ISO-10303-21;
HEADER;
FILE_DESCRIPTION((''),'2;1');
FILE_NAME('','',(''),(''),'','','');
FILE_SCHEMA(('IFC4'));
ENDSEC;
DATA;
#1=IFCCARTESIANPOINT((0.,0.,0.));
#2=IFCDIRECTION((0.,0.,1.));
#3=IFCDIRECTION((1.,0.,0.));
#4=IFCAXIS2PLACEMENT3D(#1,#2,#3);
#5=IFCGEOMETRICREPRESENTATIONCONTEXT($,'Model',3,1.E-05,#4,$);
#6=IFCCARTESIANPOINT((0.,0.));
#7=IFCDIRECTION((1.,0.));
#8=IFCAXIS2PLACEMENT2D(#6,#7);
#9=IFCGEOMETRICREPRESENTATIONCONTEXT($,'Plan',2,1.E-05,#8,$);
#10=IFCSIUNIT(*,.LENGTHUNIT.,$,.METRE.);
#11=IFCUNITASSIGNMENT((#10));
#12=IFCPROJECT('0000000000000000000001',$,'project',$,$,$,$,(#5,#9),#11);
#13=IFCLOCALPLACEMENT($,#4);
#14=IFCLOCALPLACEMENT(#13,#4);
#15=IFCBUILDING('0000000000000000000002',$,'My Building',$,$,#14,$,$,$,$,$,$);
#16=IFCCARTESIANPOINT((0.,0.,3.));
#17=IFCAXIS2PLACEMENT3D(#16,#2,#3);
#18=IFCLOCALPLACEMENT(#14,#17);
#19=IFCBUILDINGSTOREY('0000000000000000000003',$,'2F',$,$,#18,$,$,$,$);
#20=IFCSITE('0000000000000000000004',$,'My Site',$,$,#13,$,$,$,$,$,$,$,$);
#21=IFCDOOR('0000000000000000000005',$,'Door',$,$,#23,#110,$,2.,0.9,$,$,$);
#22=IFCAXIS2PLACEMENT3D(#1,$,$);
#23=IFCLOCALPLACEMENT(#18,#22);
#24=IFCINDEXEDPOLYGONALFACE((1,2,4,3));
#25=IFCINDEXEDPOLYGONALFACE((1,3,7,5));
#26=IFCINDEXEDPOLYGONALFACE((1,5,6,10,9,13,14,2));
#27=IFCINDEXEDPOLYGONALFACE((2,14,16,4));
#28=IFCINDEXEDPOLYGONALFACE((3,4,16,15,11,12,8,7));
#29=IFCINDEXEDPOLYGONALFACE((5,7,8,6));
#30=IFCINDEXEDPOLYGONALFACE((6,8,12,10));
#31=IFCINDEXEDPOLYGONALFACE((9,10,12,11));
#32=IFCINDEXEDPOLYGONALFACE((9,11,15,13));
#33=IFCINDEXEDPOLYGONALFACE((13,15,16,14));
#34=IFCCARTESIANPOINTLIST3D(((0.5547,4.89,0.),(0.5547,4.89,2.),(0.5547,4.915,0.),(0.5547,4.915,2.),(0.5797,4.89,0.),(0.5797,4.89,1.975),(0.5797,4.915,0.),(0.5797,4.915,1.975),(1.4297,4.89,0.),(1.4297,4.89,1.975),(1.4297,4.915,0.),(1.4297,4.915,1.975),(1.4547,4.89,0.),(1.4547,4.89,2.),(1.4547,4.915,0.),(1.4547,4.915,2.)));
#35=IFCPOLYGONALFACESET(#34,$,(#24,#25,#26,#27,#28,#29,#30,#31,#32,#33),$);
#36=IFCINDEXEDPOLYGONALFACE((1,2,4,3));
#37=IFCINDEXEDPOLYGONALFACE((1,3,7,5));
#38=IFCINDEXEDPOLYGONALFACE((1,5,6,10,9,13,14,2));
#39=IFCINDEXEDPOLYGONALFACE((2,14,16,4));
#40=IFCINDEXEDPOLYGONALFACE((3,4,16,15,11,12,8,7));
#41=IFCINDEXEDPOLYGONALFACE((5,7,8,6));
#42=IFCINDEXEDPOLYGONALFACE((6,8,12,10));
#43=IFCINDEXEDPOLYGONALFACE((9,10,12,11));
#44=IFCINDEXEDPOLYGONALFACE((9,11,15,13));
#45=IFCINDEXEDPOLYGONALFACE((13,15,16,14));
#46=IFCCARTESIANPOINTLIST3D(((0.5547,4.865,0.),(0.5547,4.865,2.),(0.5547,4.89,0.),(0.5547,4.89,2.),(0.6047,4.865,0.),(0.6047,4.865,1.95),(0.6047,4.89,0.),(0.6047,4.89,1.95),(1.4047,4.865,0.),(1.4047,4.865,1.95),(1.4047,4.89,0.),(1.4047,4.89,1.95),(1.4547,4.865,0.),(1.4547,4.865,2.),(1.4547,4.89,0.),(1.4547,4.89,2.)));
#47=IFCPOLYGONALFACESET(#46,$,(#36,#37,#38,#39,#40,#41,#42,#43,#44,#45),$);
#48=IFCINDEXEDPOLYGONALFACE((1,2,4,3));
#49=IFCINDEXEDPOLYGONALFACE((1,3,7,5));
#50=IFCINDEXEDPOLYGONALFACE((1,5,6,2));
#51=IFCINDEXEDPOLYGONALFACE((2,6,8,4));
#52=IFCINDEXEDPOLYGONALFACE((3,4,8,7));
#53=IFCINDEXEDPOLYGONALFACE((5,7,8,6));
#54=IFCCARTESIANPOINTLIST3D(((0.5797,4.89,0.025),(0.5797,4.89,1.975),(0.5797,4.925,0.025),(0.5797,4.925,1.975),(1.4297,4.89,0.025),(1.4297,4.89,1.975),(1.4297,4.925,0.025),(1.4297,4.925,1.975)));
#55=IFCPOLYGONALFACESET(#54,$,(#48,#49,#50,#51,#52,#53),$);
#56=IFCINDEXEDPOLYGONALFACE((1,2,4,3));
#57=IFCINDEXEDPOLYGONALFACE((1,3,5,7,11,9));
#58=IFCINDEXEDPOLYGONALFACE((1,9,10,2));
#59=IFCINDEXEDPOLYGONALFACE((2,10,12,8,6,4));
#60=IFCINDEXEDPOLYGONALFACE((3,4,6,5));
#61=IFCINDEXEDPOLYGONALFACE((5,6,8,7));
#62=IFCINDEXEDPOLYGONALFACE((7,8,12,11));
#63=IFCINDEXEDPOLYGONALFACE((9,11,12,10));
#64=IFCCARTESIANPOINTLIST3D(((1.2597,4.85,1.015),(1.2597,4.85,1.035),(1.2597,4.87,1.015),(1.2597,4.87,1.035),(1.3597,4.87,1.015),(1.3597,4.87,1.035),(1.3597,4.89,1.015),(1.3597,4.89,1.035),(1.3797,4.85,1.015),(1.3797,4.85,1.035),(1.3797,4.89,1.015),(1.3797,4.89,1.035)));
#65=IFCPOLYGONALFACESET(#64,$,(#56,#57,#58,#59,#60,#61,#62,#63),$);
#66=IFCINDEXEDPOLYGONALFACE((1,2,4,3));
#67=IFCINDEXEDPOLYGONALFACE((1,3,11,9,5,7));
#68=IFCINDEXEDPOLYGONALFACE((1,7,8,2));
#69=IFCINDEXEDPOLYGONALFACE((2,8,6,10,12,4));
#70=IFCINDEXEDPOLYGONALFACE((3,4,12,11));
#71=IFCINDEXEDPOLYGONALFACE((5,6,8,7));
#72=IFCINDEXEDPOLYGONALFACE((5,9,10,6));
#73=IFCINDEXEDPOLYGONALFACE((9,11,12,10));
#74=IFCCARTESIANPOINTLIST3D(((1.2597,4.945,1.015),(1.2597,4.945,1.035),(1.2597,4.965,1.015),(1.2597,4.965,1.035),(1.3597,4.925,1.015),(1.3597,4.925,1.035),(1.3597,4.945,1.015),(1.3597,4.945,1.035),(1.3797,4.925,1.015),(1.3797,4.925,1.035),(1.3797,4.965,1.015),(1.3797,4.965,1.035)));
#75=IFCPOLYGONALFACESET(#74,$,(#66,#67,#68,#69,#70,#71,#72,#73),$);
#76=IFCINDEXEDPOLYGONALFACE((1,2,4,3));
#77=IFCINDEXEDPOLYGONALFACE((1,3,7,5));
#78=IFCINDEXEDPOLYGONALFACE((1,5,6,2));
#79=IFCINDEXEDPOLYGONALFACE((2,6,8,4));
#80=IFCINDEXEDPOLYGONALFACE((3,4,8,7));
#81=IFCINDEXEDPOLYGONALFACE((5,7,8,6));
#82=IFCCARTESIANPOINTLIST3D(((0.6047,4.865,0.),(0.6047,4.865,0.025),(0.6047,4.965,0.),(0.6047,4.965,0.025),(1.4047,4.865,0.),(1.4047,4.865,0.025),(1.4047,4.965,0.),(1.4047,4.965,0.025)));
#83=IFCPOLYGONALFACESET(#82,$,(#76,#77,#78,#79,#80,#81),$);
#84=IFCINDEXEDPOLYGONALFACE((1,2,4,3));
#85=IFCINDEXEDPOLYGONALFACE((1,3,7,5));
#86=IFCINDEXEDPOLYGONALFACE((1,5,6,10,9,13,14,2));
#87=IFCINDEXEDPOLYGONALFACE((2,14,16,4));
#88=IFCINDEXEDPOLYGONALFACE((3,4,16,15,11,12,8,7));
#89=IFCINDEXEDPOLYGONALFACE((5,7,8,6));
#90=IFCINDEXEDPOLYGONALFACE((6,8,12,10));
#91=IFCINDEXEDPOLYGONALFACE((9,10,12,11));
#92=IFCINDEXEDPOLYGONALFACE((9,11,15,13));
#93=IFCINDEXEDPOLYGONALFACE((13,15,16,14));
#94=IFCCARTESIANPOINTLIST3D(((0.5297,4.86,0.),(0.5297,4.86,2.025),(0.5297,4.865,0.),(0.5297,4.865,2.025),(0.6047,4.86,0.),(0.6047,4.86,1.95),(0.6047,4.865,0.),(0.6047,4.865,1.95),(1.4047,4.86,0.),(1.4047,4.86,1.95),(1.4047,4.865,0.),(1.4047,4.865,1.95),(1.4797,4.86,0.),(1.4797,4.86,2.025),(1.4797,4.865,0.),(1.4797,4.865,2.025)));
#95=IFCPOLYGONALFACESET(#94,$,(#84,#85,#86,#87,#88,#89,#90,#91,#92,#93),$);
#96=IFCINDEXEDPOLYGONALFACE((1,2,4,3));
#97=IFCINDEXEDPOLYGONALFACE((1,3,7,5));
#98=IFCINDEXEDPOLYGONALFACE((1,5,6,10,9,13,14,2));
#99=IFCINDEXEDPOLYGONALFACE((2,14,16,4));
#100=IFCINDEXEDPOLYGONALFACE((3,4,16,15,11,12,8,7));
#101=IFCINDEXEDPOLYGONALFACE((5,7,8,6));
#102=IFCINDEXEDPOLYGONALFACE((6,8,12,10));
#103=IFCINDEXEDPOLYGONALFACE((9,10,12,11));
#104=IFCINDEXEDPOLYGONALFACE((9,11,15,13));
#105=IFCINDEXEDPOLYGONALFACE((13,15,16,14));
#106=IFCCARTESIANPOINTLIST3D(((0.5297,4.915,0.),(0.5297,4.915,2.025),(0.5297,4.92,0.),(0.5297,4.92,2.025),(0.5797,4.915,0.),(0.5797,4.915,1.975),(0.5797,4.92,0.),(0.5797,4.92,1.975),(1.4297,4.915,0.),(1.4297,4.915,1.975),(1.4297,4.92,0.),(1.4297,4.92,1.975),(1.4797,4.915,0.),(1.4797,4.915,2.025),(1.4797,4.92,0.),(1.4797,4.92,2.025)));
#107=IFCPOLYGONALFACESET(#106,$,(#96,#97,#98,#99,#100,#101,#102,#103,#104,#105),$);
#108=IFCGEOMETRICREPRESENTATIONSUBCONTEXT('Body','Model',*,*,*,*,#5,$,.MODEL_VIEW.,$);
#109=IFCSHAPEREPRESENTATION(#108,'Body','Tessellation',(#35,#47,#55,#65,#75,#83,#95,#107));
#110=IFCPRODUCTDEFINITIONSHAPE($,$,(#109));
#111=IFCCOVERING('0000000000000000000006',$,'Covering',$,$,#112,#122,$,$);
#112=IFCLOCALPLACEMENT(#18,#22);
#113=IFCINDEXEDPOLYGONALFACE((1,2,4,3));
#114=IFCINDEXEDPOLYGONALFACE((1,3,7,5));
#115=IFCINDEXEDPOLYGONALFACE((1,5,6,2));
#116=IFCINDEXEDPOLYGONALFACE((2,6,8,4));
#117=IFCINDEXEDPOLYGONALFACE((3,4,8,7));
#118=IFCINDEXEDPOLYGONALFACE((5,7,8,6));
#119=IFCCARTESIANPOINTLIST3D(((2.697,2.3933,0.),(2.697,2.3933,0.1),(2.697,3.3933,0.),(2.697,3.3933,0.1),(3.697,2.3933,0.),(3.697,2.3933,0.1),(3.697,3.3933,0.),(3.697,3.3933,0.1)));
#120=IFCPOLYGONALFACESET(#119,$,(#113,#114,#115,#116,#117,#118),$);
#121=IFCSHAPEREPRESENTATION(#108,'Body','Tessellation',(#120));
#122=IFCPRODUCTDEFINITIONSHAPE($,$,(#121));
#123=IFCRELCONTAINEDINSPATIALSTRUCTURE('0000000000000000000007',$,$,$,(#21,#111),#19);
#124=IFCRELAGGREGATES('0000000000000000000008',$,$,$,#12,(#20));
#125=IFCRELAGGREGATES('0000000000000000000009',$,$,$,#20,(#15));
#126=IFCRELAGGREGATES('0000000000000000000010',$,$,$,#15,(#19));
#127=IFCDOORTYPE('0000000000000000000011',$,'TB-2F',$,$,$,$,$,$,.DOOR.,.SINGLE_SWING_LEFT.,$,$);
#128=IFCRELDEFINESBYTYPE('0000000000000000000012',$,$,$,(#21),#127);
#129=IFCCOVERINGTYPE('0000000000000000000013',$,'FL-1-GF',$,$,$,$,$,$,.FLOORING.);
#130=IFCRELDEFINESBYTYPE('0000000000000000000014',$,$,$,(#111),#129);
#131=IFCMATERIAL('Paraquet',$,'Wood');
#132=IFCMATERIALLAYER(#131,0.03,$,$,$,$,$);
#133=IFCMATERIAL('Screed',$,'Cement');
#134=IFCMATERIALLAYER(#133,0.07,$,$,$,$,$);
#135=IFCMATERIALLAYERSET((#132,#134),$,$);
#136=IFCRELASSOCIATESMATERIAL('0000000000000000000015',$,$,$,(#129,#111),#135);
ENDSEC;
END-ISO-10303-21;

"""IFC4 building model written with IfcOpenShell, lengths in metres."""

from ifc_helpers import new_model, entity, si_unit, frame, origin_with_axes, origin_2d_with_axis, place, context, subcontext, project, spatial, line, indexed_curve, outline, extrude, shape, source, transform, mapped, material, layer, layer_set, layer_usage, type_object, type_shapes, element, save


model = new_model("IFC4")

# Units and contexts
model_context = context("Model", 3, precision=1e-05, world=origin_with_axes())
plan_context = context("Plan", 2, precision=1e-05, world=origin_2d_with_axis())
body_context_1 = subcontext(model_context, "Body", "Model", "MODEL_VIEW")
body_context_2 = subcontext(plan_context, "Body", "Plan", "PLAN_VIEW")
ifc_project = project(units=[si_unit("LENGTHUNIT", "METRE")], contexts=[model_context, plan_context])

# Site, building, storey
site_placement = place(None, origin_with_axes())
site = spatial("IfcSite", under=ifc_project, at=site_placement, Name="My Site")
building_placement = place(site_placement, origin_with_axes())
building = spatial("IfcBuilding", under=site, at=building_placement, Name="My Building")
storey_placement = place(building_placement, frame((0.0, 0.0, 3.0), z_axis=(0.0, 0.0, 1.0), x_axis=(1.0, 0.0, 0.0)))
storey = spatial("IfcBuildingStorey", under=building, at=storey_placement, Name="2F")

# Shared definitions
door_type_1 = type_object("IfcDoorType", Name="TB-2F", OperationType="SINGLE_SWING_LEFT", PredefinedType="DOOR")
shared_shape_1 = source(origin_with_axes(), body_context_1, "Body", "SweptSolid", [
    extrude(outline(indexed_curve([(0.0, 0.0), (0.0, 2.0), (0.9, 2.0), (0.9, 0.0), (0.875, 0.0), (0.875, 1.975), (0.025, 1.975), (0.025, 0.0)], segments=[line(1, 2, 3, 4, 5, 6, 7, 8, 1)])), frame((0.0, 0.025, 0.0), z_axis=(0.0, -1.0, 0.0), x_axis=(1.0, 0.0, 0.0)), (0.0, 0.0, -1.0), 0.025),
    extrude(outline(indexed_curve([(0.0, 0.0), (0.0, 2.0), (0.9, 2.0), (0.9, 0.0), (0.85, 0.0), (0.85, 1.95), (0.05, 1.95), (0.05, 0.0)], segments=[line(1, 2, 3, 4, 5, 6, 7, 8, 1)])), frame((0.0, 0.0, 0.0), z_axis=(0.0, -1.0, 0.0), x_axis=(1.0, 0.0, 0.0)), (0.0, 0.0, -1.0), 0.025),
    extrude(outline(indexed_curve([(0.0, 0.0), (0.85, 0.0), (0.85, 0.035), (0.0, 0.035)], segments=[line(1, 2, 3, 4, 1)])), frame((0.025, 0.025, 0.025), z_axis=(0.0, 0.0, 1.0), x_axis=(1.0, 0.0, 0.0)), (0.0, 0.0, 1.0), 1.95),
    extrude(outline(indexed_curve([(0.0, 0.0), (0.0, -0.04), (-0.12, -0.04), (-0.12, -0.02), (-0.02, -0.02), (-0.02, 0.0)], segments=[line(1, 2, 3, 4, 5, 6, 1)])), frame((0.825, 0.025, 1.015), z_axis=(0.0, 0.0, 1.0), x_axis=(1.0, 0.0, 0.0)), (0.0, 0.0, 1.0), 0.02),
    extrude(outline(indexed_curve([(0.0, 0.0), (0.0, 0.04), (-0.12, 0.04), (-0.12, 0.02), (-0.02, 0.02), (-0.02, 0.0)], segments=[line(1, 2, 3, 4, 5, 6, 1)])), frame((0.825, 0.06, 1.015), z_axis=(0.0, 0.0, 1.0), x_axis=(1.0, 0.0, 0.0)), (0.0, 0.0, 1.0), 0.02),
    extrude(outline(indexed_curve([(0.0, 0.0), (0.8, 0.0), (0.8, 0.1), (0.0, 0.1)], segments=[line(1, 2, 3, 4, 1)])), frame((0.05, 0.0, 0.0), z_axis=(0.0, 0.0, 1.0), x_axis=(1.0, 0.0, 0.0)), (0.0, 0.0, 1.0), 0.025),
    extrude(outline(indexed_curve([(0.0, 0.0), (0.0, 2.025), (0.95, 2.025), (0.95, 0.0), (0.875, 0.0), (0.875, 1.95), (0.075, 1.95), (0.075, 0.0)], segments=[line(1, 2, 3, 4, 5, 6, 7, 8, 1)])), frame((-0.025, -0.005, 0.0), z_axis=(0.0, -1.0, 0.0), x_axis=(1.0, 0.0, 0.0)), (0.0, 0.0, -1.0), 0.005),
    extrude(outline(indexed_curve([(0.0, 0.0), (0.0, 2.025), (0.95, 2.025), (0.95, 0.0), (0.9, 0.0), (0.9, 1.975), (0.05, 1.975), (0.05, 0.0)], segments=[line(1, 2, 3, 4, 5, 6, 7, 8, 1)])), frame((-0.025, 0.05, 0.0), z_axis=(0.0, -1.0, 0.0), x_axis=(1.0, 0.0, 0.0)), (0.0, 0.0, -1.0), 0.005),
])
shared_shape_2 = source(origin_with_axes(), body_context_2, "Body", "Curve2D", [
    entity("IfcIndexedPolyCurve", entity("IfcCartesianPointList2D", [[0.0, 0.0], [0.0, 0.05], [0.025, 0.05], [0.025, 0.025], [0.05, 0.025], [0.05, 0.0]]), [entity("IfcLineIndex", [1, 2, 3, 4, 5, 6, 1])]),
    entity("IfcIndexedPolyCurve", entity("IfcCartesianPointList2D", [[0.9, 0.0], [0.9, 0.05], [0.875, 0.05], [0.875, 0.025], [0.85, 0.025], [0.85, 0.0]]), [entity("IfcLineIndex", [1, 2, 3, 4, 5, 6, 1])]),
    entity("IfcTrimmedCurve", entity("IfcEllipse", entity("IfcAxis2Placement2D", entity("IfcCartesianPoint", [0.06, 0.05]), entity("IfcDirection", [1.0, 0.0])), 0.815, 0.85), [entity("IfcCartesianPoint", [0.875, 0.05])], [entity("IfcCartesianPoint", [0.06, 0.9])], True, "CARTESIAN"),
    entity("IfcIndexedPolyCurve", entity("IfcCartesianPointList2D", [[0.025, 0.05], [0.06, 0.05], [0.06, 0.9], [0.025, 0.9]]), [entity("IfcLineIndex", [1, 2, 3, 4, 1])]),
])
type_shapes(door_type_1, [shared_shape_1, shared_shape_2])

# Door
door_1_placement = place(storey_placement, frame((0.5547, 4.865, 0.0), z_axis=(0.0, 0.0, 1.0), x_axis=(1.0, 0.0, 0.0)))
element("IfcDoor", 1, at=door_1_placement, inside=storey, type_object=door_type_1, Name="Door", OverallHeight=2.0, OverallWidth=0.9, shapes=[
    shape(body_context_1, "Body", "MappedRepresentation", [mapped(shared_shape_1, transform((0.0, 0.0, 0.0), x_axis=(1.0, 0.0, 0.0), y_axis=(0.0, 1.0, 0.0), z_axis=(0.0, 0.0, 1.0), scale=1.0))]),
    shape(body_context_2, "Body", "MappedRepresentation", [mapped(shared_shape_2, transform((0.0, 0.0, 0.0), x_axis=(1.0, 0.0, 0.0), y_axis=(0.0, 1.0, 0.0), z_axis=(0.0, 0.0, 1.0), scale=1.0))]),
])

# Covering
ifc_material_1 = material(Name="Paraquet", Category="Wood")
ifc_layer_1 = layer(ifc_material_1, 0.03)
ifc_material_2 = material(Name="Screed", Category="Cement")
ifc_layer_2 = layer(ifc_material_2, 0.07)
ifc_layer_set_1 = layer_set([ifc_layer_1, ifc_layer_2])
ifc_layer_usage_1 = layer_usage(ifc_layer_set_1, "AXIS3", "POSITIVE", 0.0)
covering_type = type_object("IfcCoveringType", Name="FL-1-GF", PredefinedType="FLOORING", material=ifc_layer_set_1)
covering_1_placement = place(storey_placement, frame((2.697, 2.3933, 0.0), z_axis=(0.0, 0.0, 1.0), x_axis=(1.0, 0.0, 0.0)))
element("IfcCovering", 2, at=covering_1_placement, inside=storey, type_object=covering_type, material=ifc_layer_usage_1, Name="Covering", context=body_context_1, shape_type="SweptSolid", body=[
    extrude(outline(indexed_curve([(0.0, 0.0), (1.0, 0.0), (1.0, 1.0), (0.0, 1.0), (0.0, 0.0)])), origin_with_axes(), (0.0, 0.0, 1.0), 0.1),
])

save(model, "model.ifc")
